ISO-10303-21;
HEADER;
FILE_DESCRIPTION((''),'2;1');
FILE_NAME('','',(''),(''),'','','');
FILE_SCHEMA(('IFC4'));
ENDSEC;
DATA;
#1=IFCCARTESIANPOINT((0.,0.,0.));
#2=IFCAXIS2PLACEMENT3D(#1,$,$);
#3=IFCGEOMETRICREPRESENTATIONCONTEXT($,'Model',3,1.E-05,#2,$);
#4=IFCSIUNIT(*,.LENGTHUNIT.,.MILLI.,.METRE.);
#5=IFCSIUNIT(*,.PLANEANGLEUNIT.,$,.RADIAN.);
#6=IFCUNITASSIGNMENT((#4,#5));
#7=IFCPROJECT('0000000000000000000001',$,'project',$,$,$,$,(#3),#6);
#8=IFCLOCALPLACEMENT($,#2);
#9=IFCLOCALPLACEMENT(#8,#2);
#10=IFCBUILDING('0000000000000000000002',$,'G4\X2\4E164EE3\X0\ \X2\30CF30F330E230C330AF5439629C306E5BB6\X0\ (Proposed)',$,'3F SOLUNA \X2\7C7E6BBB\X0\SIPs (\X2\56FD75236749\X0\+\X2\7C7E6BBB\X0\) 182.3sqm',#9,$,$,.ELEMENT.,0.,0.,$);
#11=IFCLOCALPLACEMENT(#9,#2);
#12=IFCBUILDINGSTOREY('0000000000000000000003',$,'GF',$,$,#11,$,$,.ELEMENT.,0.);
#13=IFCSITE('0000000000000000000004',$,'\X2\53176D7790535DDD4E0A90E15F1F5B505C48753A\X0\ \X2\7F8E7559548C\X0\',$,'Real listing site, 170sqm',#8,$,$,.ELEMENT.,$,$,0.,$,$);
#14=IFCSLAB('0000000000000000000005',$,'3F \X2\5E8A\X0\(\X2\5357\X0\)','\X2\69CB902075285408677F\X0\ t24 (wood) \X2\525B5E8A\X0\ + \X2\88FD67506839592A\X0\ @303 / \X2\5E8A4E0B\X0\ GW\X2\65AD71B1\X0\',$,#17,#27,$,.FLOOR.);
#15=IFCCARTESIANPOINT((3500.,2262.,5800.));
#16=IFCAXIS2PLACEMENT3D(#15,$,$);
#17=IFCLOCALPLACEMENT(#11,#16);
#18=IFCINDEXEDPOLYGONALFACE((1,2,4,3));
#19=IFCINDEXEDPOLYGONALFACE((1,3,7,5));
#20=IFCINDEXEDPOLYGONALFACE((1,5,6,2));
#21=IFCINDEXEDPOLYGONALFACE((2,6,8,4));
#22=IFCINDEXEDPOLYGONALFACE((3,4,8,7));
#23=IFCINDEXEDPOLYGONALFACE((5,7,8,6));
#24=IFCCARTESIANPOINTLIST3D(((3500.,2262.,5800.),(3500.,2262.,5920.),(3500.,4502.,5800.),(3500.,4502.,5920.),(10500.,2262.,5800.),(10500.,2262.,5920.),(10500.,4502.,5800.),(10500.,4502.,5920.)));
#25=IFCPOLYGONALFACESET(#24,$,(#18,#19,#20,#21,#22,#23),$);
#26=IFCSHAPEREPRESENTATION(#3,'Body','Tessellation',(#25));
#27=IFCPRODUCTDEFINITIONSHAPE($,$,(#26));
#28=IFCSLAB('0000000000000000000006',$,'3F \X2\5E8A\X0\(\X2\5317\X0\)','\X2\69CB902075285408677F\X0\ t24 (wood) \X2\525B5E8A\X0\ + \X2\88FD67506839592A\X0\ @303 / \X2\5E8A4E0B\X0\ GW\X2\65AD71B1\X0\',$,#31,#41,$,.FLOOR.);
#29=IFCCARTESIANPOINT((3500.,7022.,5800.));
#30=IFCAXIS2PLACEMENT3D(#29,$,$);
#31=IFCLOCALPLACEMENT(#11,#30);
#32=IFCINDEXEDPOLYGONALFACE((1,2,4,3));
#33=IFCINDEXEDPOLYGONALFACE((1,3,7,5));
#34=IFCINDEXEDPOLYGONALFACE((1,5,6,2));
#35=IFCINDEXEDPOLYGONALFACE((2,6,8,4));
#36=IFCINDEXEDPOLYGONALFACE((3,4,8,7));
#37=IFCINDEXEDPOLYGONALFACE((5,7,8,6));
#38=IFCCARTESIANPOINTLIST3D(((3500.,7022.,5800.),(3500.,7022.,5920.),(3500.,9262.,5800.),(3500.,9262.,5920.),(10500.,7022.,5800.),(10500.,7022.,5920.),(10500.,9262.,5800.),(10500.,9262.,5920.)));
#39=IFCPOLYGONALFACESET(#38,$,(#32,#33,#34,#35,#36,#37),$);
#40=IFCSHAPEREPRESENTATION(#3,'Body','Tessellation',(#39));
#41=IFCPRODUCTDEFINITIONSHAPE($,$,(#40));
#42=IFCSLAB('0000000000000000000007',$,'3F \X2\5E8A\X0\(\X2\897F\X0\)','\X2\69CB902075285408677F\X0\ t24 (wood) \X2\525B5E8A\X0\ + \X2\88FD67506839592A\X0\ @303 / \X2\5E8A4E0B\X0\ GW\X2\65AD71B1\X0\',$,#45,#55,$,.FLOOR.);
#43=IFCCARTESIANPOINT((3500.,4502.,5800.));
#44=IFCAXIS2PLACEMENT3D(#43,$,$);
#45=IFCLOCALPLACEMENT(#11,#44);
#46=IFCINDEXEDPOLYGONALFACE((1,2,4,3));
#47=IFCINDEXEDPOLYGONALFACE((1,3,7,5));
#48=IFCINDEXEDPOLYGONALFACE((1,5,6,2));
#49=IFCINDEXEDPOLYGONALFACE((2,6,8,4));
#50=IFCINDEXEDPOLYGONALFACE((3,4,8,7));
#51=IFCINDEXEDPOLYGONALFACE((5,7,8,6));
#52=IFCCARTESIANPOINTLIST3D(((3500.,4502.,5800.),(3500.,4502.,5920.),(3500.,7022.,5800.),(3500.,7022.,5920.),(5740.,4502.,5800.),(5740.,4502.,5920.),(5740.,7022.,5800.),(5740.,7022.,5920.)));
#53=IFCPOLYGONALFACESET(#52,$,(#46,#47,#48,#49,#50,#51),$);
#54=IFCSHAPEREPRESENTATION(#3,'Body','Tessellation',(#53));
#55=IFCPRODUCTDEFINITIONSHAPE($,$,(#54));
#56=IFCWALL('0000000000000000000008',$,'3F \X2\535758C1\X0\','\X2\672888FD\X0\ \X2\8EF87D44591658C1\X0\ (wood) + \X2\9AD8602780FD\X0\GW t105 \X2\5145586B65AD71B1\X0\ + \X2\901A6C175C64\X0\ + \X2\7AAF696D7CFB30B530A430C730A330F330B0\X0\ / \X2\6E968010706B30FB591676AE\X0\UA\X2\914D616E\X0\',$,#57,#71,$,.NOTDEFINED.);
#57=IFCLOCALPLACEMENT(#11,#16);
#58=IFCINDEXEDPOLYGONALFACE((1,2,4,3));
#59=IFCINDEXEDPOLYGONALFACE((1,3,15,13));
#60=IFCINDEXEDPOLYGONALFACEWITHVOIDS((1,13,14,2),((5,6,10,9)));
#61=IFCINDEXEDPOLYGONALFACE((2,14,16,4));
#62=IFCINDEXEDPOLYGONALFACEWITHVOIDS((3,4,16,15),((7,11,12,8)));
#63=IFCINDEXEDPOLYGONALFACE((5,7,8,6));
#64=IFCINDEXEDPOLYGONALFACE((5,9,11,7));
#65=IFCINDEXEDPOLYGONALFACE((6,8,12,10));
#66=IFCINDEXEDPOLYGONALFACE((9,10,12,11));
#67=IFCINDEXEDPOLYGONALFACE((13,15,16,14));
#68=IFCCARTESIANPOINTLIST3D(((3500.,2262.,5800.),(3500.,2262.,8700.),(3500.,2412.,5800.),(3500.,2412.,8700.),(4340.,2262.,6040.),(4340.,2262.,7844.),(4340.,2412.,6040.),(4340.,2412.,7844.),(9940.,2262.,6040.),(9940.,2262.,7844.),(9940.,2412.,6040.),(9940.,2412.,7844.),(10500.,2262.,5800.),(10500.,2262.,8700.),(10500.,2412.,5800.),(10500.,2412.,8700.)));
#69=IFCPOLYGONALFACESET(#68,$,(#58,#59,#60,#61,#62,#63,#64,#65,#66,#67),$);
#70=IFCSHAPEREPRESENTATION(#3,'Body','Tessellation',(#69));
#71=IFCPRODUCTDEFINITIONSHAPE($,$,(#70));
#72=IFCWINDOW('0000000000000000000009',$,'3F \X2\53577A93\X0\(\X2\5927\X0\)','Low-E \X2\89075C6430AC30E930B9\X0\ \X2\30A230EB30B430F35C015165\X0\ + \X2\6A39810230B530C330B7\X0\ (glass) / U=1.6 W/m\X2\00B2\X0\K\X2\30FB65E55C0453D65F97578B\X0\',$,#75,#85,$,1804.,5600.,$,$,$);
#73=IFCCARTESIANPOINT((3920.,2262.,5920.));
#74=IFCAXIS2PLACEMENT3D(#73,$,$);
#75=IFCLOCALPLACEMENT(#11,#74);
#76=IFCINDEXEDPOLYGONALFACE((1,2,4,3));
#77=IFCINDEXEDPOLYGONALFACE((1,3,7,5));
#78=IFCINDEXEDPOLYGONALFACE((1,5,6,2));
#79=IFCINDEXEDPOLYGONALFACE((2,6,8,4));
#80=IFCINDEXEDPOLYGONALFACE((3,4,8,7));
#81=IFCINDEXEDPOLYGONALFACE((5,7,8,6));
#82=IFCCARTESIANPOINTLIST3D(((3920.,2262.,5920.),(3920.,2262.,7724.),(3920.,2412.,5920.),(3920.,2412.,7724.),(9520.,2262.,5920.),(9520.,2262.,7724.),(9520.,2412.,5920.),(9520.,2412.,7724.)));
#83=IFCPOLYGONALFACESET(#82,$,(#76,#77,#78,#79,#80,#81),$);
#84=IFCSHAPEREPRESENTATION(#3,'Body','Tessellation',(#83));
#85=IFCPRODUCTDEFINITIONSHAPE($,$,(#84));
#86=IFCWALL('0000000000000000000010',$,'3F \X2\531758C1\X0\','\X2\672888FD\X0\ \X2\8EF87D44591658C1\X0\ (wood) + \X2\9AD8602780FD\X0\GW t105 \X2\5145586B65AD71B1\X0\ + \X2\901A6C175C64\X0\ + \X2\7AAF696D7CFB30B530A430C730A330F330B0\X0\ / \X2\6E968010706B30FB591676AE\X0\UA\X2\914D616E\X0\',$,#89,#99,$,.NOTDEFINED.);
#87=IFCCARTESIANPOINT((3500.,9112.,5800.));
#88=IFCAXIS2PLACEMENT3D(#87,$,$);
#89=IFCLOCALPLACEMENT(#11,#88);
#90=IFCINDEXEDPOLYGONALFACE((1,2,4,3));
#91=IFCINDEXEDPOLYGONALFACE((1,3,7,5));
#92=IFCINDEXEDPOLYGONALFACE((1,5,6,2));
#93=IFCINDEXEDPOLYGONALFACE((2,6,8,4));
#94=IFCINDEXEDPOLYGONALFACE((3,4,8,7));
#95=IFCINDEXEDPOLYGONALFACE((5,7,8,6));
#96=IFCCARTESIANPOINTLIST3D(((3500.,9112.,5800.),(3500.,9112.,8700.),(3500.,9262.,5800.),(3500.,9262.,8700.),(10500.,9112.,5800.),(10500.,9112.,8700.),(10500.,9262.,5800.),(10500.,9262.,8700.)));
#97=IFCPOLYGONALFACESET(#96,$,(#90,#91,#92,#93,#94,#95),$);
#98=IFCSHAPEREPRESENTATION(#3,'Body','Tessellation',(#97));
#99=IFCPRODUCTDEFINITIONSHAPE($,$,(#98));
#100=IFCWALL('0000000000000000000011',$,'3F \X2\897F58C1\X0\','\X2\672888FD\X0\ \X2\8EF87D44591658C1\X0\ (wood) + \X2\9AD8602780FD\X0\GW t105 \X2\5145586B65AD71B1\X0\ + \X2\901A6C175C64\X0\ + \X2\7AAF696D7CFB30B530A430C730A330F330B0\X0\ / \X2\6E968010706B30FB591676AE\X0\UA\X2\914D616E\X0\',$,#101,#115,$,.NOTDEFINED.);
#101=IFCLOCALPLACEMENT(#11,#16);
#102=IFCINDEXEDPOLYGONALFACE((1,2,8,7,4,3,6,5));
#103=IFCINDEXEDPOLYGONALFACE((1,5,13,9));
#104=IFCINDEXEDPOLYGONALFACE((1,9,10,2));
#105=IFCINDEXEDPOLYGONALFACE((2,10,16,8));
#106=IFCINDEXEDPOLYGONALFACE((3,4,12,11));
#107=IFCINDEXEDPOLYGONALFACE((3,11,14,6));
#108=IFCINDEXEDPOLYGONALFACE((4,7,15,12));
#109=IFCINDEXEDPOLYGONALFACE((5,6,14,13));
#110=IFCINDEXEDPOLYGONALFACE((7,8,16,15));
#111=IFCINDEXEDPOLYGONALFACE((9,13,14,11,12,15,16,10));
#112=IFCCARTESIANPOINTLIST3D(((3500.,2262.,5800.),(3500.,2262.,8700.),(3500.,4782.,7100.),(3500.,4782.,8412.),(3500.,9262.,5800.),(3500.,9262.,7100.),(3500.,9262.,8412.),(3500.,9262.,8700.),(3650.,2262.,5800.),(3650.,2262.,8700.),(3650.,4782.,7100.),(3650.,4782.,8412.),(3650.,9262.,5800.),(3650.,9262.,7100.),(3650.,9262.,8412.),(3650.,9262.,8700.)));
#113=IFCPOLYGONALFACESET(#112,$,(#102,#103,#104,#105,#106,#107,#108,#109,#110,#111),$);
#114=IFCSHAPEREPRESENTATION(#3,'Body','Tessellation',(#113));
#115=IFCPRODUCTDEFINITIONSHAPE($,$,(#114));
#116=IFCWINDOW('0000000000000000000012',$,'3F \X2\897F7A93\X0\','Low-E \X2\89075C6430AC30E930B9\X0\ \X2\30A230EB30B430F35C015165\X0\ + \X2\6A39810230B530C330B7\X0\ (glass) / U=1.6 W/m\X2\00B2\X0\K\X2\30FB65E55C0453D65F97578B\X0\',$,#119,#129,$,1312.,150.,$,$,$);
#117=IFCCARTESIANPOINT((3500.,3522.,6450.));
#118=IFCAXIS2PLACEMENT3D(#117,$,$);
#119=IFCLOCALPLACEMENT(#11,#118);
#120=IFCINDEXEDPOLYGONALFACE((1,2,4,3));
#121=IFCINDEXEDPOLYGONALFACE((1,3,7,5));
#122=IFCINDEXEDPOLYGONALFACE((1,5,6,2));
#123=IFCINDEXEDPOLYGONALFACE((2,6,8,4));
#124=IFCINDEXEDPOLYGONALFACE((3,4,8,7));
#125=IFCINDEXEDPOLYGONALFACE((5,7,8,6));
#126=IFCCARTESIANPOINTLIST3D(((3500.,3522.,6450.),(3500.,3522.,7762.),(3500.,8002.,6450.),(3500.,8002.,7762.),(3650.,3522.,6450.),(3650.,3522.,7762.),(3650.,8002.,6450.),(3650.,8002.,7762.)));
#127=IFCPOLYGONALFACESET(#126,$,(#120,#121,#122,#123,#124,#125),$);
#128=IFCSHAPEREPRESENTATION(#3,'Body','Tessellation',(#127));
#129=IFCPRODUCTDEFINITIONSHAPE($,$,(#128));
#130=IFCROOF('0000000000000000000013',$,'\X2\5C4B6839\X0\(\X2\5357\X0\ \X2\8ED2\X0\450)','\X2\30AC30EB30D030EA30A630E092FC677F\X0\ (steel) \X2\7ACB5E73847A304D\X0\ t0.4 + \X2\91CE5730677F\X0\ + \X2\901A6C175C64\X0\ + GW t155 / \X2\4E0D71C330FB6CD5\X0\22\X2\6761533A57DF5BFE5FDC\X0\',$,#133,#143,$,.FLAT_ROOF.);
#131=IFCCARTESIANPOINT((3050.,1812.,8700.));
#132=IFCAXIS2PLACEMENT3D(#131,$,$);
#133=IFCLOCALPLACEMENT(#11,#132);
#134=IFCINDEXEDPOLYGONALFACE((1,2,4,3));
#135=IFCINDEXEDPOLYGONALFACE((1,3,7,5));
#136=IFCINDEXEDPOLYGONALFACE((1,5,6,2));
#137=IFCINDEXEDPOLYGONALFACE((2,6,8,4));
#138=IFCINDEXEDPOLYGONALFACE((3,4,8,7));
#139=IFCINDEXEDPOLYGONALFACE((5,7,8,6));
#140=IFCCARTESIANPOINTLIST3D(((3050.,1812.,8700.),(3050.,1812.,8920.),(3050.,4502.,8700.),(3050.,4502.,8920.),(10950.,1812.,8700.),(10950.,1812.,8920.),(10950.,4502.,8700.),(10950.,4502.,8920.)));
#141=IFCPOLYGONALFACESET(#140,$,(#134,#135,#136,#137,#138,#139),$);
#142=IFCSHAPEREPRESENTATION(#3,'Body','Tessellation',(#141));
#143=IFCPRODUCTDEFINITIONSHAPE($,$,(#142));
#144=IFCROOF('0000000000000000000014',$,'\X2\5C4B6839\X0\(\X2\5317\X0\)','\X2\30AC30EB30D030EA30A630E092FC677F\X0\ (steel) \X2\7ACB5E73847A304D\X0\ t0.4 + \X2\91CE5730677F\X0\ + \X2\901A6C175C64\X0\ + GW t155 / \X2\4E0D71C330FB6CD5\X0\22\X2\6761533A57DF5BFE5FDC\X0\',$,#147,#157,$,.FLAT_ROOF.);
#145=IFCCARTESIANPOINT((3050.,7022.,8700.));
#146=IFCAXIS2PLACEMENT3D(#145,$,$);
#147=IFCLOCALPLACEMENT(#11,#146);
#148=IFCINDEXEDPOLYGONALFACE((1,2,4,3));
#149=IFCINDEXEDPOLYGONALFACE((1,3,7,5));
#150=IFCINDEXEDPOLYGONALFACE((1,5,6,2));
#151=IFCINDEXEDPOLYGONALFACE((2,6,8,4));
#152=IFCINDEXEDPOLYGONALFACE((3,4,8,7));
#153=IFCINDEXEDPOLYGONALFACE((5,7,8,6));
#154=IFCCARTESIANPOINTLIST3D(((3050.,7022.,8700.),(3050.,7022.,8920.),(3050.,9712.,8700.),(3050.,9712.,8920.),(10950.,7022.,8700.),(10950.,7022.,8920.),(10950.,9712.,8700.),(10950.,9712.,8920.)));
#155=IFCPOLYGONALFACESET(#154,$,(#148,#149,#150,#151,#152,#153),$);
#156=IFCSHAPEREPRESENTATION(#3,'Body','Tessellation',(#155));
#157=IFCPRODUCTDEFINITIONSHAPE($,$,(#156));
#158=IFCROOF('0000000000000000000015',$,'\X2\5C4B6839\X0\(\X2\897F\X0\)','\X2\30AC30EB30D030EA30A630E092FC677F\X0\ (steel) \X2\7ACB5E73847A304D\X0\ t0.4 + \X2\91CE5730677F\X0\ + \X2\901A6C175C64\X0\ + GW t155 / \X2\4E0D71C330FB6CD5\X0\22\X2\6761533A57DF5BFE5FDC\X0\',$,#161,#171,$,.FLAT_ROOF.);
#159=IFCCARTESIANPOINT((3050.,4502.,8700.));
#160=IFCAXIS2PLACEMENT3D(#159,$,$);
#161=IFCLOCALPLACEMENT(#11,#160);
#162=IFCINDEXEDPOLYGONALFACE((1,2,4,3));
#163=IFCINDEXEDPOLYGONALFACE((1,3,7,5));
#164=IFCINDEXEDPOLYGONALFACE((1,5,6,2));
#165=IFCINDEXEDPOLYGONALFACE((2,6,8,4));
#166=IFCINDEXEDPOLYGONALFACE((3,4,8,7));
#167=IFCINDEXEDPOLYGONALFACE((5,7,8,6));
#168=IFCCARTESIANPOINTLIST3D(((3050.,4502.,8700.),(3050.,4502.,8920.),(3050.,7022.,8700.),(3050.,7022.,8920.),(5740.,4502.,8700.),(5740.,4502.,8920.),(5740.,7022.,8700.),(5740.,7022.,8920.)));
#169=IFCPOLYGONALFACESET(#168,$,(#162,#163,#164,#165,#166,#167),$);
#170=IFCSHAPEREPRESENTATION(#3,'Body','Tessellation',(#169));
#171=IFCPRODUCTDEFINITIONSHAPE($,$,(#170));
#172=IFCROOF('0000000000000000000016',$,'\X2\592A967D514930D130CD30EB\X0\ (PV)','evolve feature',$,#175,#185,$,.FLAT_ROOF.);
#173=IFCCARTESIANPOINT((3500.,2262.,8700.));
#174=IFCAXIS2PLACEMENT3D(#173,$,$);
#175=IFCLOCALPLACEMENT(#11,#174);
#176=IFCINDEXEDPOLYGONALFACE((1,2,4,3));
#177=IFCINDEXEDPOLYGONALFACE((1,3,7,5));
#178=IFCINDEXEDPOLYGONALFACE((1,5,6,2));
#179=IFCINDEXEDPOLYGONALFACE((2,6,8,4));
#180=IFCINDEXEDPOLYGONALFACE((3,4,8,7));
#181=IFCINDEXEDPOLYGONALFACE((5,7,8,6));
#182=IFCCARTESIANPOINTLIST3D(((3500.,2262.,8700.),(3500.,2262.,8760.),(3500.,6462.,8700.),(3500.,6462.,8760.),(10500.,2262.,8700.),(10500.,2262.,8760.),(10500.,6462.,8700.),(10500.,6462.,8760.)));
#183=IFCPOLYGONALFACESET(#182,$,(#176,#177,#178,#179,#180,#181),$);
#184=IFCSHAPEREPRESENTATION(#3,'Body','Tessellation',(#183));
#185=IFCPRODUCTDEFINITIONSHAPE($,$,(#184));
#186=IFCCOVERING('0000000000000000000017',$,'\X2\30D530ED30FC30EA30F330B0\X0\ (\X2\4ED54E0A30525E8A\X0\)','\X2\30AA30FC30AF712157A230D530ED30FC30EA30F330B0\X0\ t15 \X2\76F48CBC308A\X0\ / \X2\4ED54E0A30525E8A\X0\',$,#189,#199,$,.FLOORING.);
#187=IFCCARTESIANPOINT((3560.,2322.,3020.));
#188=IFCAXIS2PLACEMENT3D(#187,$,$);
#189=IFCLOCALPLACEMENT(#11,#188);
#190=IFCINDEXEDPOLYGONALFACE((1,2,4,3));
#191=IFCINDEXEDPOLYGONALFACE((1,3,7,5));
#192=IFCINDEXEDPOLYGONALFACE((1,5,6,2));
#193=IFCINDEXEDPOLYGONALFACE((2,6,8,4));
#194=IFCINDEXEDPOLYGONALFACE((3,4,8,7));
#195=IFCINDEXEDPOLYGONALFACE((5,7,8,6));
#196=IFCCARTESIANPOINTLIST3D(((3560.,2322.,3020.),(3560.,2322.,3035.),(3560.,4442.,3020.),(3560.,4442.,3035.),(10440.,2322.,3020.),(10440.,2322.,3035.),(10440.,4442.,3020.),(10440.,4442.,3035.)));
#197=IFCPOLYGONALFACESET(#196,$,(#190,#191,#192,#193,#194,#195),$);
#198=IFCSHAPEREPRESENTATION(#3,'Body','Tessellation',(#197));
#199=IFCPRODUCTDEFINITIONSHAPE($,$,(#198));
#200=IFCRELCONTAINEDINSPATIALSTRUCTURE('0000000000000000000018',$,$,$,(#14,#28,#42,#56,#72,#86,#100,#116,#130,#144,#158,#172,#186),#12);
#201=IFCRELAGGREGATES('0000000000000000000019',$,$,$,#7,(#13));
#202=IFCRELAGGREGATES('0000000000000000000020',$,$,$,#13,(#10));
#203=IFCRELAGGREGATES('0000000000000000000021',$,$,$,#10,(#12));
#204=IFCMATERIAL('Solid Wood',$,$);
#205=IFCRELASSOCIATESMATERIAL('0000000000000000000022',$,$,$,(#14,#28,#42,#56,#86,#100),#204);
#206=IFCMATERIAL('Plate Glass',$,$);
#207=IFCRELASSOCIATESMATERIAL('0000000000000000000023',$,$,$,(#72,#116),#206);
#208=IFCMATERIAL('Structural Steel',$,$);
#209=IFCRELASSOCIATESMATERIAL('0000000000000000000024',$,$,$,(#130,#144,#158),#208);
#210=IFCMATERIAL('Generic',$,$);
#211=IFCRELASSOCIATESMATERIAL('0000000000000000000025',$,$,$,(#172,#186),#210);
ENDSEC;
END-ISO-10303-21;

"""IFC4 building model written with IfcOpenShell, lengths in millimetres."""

from ifc_helpers import new_model, si_unit, frame, frame_2d, origin, place, context, project, spatial, rectangle, extrude, material, element, fill, save


model = new_model("IFC4")

# Units and contexts
model_context = context("Model", 3, precision=1e-05, world=origin())
ifc_project = project(units=[si_unit("LENGTHUNIT", "METRE", prefix="MILLI"), si_unit("PLANEANGLEUNIT", "RADIAN")], contexts=[model_context])

# Site, building, storey
site_placement = place(None, origin())
site = spatial("IfcSite", under=ifc_project, at=site_placement, Name="北海道川上郡弟子屈町 美留和", ObjectType="Real listing site, 170sqm", CompositionType="ELEMENT", RefElevation=0.0)
building_placement = place(site_placement, origin())
building = spatial("IfcBuilding", under=site, at=building_placement, Name="G4世代 ハンモック吹抜の家 (Proposed)", ObjectType="3F SOLUNA 籾殻SIPs (国産杉+籾殻) 182.3sqm", CompositionType="ELEMENT", ElevationOfRefHeight=0.0, ElevationOfTerrain=0.0)
storey_placement = place(building_placement, origin())
storey = spatial("IfcBuildingStorey", under=building, at=storey_placement, Name="GF", CompositionType="ELEMENT", Elevation=0.0)

# Slabs
ifc_material_1 = material(Name="Solid Wood")
slab_1_placement = place(storey_placement, frame((3500.0, 2262.0, 5800.0)))
element("IfcSlab", 1, at=slab_1_placement, inside=storey, material=ifc_material_1, Name="3F 床(南)", Description="構造用合板 t24 (wood) 剛床 + 製材根太 @303 / 床下 GW断熱", PredefinedType="FLOOR", context=model_context, shape_type="SweptSolid", body=[
    extrude(rectangle(XDim=7000.0, YDim=2240.0, at=frame_2d((3500.0, 1120.0))), frame((3500.0, 2262.0, 5800.0)), (0.0, 0.0, 1.0), 120.0),
])
slab_2_placement = place(storey_placement, frame((3500.0, 7022.0, 5800.0)))
element("IfcSlab", 2, at=slab_2_placement, inside=storey, material=ifc_material_1, Name="3F 床(北)", Description="構造用合板 t24 (wood) 剛床 + 製材根太 @303 / 床下 GW断熱", PredefinedType="FLOOR", context=model_context, shape_type="SweptSolid", body=[
    extrude(rectangle(XDim=7000.0, YDim=2240.0, at=frame_2d((3500.0, 1120.0))), frame((3500.0, 7022.0, 5800.0)), (0.0, 0.0, 1.0), 120.0),
])
slab_3_placement = place(storey_placement, frame((3500.0, 4502.0, 5800.0)))
element("IfcSlab", 3, at=slab_3_placement, inside=storey, material=ifc_material_1, Name="3F 床(西)", Description="構造用合板 t24 (wood) 剛床 + 製材根太 @303 / 床下 GW断熱", PredefinedType="FLOOR", context=model_context, shape_type="SweptSolid", body=[
    extrude(rectangle(XDim=2240.0, YDim=2520.0, at=frame_2d((1120.0, 1260.0))), frame((3500.0, 4502.0, 5800.0)), (0.0, 0.0, 1.0), 120.0),
])

# Wall, opening, window
wall_1_placement = place(storey_placement, frame((3500.0, 2262.0, 5800.0)))
wall_1 = element("IfcWall", 4, at=wall_1_placement, inside=storey, material=ifc_material_1, Name="3F 南壁", Description="木製 軸組外壁 (wood) + 高性能GW t105 充填断熱 + 通気層 + 窯業系サイディング / 準耐火・外皮UA配慮", PredefinedType="NOTDEFINED", context=model_context, shape_type="SweptSolid", body=[
    extrude(rectangle(XDim=7000.0, YDim=150.0, at=frame_2d((3500.0, 75.0))), frame((3500.0, 2262.0, 5800.0)), (0.0, 0.0, 1.0), 2900.0),
])
opening_1_placement = place(storey_placement, frame((3920.0, 2262.0, 5920.0)))
opening_1 = element("IfcOpeningElement", 5, at=opening_1_placement, cuts=wall_1, PredefinedType="NOTDEFINED", context=model_context, shape_type="SweptSolid", body=[
    extrude(rectangle(XDim=5600.0, YDim=150.0, at=frame_2d((2800.0, 75.0))), frame((3920.0, 2262.0, 5920.0)), (0.0, 0.0, 1.0), 1804.0),
])
ifc_material_2 = material(Name="Plate Glass")
window_1_placement = place(storey_placement, frame((3920.0, 2262.0, 5920.0)))
window_1 = element("IfcWindow", 6, at=window_1_placement, inside=storey, material=ifc_material_2, Name="3F 南窓(大)", Description="Low-E 複層ガラス アルゴン封入 + 樹脂サッシ (glass) / U=1.6 W/m²K・日射取得型", OverallHeight=1804.0, OverallWidth=5600.0, context=model_context, shape_type="SweptSolid", body=[
    extrude(rectangle(XDim=5600.0, YDim=150.0, at=frame_2d((2800.0, 75.0))), frame((3920.0, 2262.0, 5920.0)), (0.0, 0.0, 1.0), 1804.0),
])
fill(opening_1, window_1)

# Wall
wall_2_placement = place(storey_placement, frame((3500.0, 9112.0, 5800.0)))
element("IfcWall", 7, at=wall_2_placement, inside=storey, material=ifc_material_1, Name="3F 北壁", Description="木製 軸組外壁 (wood) + 高性能GW t105 充填断熱 + 通気層 + 窯業系サイディング / 準耐火・外皮UA配慮", PredefinedType="NOTDEFINED", context=model_context, shape_type="SweptSolid", body=[
    extrude(rectangle(XDim=7000.0, YDim=150.0, at=frame_2d((3500.0, 75.0))), frame((3500.0, 9112.0, 5800.0)), (0.0, 0.0, 1.0), 2900.0),
])

# Wall, opening, window
wall_3_placement = place(storey_placement, frame((3500.0, 2262.0, 5800.0)))
wall_3 = element("IfcWall", 8, at=wall_3_placement, inside=storey, material=ifc_material_1, Name="3F 西壁", Description="木製 軸組外壁 (wood) + 高性能GW t105 充填断熱 + 通気層 + 窯業系サイディング / 準耐火・外皮UA配慮", PredefinedType="NOTDEFINED", context=model_context, shape_type="SweptSolid", body=[
    extrude(rectangle(XDim=150.0, YDim=7000.0, at=frame_2d((75.0, 3500.0))), frame((3500.0, 2262.0, 5800.0)), (0.0, 0.0, 1.0), 2900.0),
])
opening_2_placement = place(storey_placement, frame((3500.0, 3522.0, 6450.0)))
opening_2 = element("IfcOpeningElement", 9, at=opening_2_placement, cuts=wall_3, PredefinedType="NOTDEFINED", context=model_context, shape_type="SweptSolid", body=[
    extrude(rectangle(XDim=150.0, YDim=4480.0, at=frame_2d((75.0, 2240.0))), frame((3500.0, 3522.0, 6450.0)), (0.0, 0.0, 1.0), 1312.0),
])
window_2_placement = place(storey_placement, frame((3500.0, 3522.0, 6450.0)))
window_2 = element("IfcWindow", 10, at=window_2_placement, inside=storey, material=ifc_material_2, Name="3F 西窓", Description="Low-E 複層ガラス アルゴン封入 + 樹脂サッシ (glass) / U=1.6 W/m²K・日射取得型", OverallHeight=1312.0, OverallWidth=150.0, context=model_context, shape_type="SweptSolid", body=[
    extrude(rectangle(XDim=150.0, YDim=4480.0, at=frame_2d((75.0, 2240.0))), frame((3500.0, 3522.0, 6450.0)), (0.0, 0.0, 1.0), 1312.0),
])
fill(opening_2, window_2)

# Roofs
ifc_material_3 = material(Name="Structural Steel")
roof_1_placement = place(storey_placement, frame((3050.0, 1812.0, 8700.0)))
element("IfcRoof", 11, at=roof_1_placement, inside=storey, material=ifc_material_3, Name="屋根(南 軒450)", Description="ガルバリウム鋼板 (steel) 立平葺き t0.4 + 野地板 + 通気層 + GW t155 / 不燃・法22条区域対応", PredefinedType="FLAT_ROOF", context=model_context, shape_type="SweptSolid", body=[
    extrude(rectangle(XDim=7900.0, YDim=2690.0, at=frame_2d((3950.0, 1345.0))), frame((3050.0, 1812.0, 8700.0)), (0.0, 0.0, 1.0), 220.0),
])
roof_2_placement = place(storey_placement, frame((3050.0, 7022.0, 8700.0)))
element("IfcRoof", 12, at=roof_2_placement, inside=storey, material=ifc_material_3, Name="屋根(北)", Description="ガルバリウム鋼板 (steel) 立平葺き t0.4 + 野地板 + 通気層 + GW t155 / 不燃・法22条区域対応", PredefinedType="FLAT_ROOF", context=model_context, shape_type="SweptSolid", body=[
    extrude(rectangle(XDim=7900.0, YDim=2690.0, at=frame_2d((3950.0, 1345.0))), frame((3050.0, 7022.0, 8700.0)), (0.0, 0.0, 1.0), 220.0),
])
roof_3_placement = place(storey_placement, frame((3050.0, 4502.0, 8700.0)))
element("IfcRoof", 13, at=roof_3_placement, inside=storey, material=ifc_material_3, Name="屋根(西)", Description="ガルバリウム鋼板 (steel) 立平葺き t0.4 + 野地板 + 通気層 + GW t155 / 不燃・法22条区域対応", PredefinedType="FLAT_ROOF", context=model_context, shape_type="SweptSolid", body=[
    extrude(rectangle(XDim=2690.0, YDim=2520.0, at=frame_2d((1345.0, 1260.0))), frame((3050.0, 4502.0, 8700.0)), (0.0, 0.0, 1.0), 220.0),
])
ifc_material_4 = material(Name="Generic")
roof_4_placement = place(storey_placement, frame((3500.0, 2262.0, 8700.0)))
element("IfcRoof", 14, at=roof_4_placement, inside=storey, material=ifc_material_4, Name="太陽光パネル (PV)", Description="evolve feature", PredefinedType="FLAT_ROOF", context=model_context, shape_type="SweptSolid", body=[
    extrude(rectangle(XDim=7000.0, YDim=4200.0, at=frame_2d((3500.0, 2100.0))), frame((3500.0, 2262.0, 8700.0)), (0.0, 0.0, 1.0), 60.0),
])

# Covering
covering_1_placement = place(storey_placement, frame((3560.0, 2322.0, 3020.0)))
element("IfcCovering", 15, at=covering_1_placement, inside=storey, material=ifc_material_4, Name="フローリング (仕上げ床)", Description="オーク無垢フローリング t15 直貼り / 仕上げ床", PredefinedType="FLOORING", context=model_context, shape_type="SweptSolid", body=[
    extrude(rectangle(XDim=6880.0, YDim=2120.0, at=frame_2d((3440.0, 1060.0))), frame((3560.0, 2322.0, 3020.0)), (0.0, 0.0, 1.0), 15.0),
])

save(model, "model.ifc")
